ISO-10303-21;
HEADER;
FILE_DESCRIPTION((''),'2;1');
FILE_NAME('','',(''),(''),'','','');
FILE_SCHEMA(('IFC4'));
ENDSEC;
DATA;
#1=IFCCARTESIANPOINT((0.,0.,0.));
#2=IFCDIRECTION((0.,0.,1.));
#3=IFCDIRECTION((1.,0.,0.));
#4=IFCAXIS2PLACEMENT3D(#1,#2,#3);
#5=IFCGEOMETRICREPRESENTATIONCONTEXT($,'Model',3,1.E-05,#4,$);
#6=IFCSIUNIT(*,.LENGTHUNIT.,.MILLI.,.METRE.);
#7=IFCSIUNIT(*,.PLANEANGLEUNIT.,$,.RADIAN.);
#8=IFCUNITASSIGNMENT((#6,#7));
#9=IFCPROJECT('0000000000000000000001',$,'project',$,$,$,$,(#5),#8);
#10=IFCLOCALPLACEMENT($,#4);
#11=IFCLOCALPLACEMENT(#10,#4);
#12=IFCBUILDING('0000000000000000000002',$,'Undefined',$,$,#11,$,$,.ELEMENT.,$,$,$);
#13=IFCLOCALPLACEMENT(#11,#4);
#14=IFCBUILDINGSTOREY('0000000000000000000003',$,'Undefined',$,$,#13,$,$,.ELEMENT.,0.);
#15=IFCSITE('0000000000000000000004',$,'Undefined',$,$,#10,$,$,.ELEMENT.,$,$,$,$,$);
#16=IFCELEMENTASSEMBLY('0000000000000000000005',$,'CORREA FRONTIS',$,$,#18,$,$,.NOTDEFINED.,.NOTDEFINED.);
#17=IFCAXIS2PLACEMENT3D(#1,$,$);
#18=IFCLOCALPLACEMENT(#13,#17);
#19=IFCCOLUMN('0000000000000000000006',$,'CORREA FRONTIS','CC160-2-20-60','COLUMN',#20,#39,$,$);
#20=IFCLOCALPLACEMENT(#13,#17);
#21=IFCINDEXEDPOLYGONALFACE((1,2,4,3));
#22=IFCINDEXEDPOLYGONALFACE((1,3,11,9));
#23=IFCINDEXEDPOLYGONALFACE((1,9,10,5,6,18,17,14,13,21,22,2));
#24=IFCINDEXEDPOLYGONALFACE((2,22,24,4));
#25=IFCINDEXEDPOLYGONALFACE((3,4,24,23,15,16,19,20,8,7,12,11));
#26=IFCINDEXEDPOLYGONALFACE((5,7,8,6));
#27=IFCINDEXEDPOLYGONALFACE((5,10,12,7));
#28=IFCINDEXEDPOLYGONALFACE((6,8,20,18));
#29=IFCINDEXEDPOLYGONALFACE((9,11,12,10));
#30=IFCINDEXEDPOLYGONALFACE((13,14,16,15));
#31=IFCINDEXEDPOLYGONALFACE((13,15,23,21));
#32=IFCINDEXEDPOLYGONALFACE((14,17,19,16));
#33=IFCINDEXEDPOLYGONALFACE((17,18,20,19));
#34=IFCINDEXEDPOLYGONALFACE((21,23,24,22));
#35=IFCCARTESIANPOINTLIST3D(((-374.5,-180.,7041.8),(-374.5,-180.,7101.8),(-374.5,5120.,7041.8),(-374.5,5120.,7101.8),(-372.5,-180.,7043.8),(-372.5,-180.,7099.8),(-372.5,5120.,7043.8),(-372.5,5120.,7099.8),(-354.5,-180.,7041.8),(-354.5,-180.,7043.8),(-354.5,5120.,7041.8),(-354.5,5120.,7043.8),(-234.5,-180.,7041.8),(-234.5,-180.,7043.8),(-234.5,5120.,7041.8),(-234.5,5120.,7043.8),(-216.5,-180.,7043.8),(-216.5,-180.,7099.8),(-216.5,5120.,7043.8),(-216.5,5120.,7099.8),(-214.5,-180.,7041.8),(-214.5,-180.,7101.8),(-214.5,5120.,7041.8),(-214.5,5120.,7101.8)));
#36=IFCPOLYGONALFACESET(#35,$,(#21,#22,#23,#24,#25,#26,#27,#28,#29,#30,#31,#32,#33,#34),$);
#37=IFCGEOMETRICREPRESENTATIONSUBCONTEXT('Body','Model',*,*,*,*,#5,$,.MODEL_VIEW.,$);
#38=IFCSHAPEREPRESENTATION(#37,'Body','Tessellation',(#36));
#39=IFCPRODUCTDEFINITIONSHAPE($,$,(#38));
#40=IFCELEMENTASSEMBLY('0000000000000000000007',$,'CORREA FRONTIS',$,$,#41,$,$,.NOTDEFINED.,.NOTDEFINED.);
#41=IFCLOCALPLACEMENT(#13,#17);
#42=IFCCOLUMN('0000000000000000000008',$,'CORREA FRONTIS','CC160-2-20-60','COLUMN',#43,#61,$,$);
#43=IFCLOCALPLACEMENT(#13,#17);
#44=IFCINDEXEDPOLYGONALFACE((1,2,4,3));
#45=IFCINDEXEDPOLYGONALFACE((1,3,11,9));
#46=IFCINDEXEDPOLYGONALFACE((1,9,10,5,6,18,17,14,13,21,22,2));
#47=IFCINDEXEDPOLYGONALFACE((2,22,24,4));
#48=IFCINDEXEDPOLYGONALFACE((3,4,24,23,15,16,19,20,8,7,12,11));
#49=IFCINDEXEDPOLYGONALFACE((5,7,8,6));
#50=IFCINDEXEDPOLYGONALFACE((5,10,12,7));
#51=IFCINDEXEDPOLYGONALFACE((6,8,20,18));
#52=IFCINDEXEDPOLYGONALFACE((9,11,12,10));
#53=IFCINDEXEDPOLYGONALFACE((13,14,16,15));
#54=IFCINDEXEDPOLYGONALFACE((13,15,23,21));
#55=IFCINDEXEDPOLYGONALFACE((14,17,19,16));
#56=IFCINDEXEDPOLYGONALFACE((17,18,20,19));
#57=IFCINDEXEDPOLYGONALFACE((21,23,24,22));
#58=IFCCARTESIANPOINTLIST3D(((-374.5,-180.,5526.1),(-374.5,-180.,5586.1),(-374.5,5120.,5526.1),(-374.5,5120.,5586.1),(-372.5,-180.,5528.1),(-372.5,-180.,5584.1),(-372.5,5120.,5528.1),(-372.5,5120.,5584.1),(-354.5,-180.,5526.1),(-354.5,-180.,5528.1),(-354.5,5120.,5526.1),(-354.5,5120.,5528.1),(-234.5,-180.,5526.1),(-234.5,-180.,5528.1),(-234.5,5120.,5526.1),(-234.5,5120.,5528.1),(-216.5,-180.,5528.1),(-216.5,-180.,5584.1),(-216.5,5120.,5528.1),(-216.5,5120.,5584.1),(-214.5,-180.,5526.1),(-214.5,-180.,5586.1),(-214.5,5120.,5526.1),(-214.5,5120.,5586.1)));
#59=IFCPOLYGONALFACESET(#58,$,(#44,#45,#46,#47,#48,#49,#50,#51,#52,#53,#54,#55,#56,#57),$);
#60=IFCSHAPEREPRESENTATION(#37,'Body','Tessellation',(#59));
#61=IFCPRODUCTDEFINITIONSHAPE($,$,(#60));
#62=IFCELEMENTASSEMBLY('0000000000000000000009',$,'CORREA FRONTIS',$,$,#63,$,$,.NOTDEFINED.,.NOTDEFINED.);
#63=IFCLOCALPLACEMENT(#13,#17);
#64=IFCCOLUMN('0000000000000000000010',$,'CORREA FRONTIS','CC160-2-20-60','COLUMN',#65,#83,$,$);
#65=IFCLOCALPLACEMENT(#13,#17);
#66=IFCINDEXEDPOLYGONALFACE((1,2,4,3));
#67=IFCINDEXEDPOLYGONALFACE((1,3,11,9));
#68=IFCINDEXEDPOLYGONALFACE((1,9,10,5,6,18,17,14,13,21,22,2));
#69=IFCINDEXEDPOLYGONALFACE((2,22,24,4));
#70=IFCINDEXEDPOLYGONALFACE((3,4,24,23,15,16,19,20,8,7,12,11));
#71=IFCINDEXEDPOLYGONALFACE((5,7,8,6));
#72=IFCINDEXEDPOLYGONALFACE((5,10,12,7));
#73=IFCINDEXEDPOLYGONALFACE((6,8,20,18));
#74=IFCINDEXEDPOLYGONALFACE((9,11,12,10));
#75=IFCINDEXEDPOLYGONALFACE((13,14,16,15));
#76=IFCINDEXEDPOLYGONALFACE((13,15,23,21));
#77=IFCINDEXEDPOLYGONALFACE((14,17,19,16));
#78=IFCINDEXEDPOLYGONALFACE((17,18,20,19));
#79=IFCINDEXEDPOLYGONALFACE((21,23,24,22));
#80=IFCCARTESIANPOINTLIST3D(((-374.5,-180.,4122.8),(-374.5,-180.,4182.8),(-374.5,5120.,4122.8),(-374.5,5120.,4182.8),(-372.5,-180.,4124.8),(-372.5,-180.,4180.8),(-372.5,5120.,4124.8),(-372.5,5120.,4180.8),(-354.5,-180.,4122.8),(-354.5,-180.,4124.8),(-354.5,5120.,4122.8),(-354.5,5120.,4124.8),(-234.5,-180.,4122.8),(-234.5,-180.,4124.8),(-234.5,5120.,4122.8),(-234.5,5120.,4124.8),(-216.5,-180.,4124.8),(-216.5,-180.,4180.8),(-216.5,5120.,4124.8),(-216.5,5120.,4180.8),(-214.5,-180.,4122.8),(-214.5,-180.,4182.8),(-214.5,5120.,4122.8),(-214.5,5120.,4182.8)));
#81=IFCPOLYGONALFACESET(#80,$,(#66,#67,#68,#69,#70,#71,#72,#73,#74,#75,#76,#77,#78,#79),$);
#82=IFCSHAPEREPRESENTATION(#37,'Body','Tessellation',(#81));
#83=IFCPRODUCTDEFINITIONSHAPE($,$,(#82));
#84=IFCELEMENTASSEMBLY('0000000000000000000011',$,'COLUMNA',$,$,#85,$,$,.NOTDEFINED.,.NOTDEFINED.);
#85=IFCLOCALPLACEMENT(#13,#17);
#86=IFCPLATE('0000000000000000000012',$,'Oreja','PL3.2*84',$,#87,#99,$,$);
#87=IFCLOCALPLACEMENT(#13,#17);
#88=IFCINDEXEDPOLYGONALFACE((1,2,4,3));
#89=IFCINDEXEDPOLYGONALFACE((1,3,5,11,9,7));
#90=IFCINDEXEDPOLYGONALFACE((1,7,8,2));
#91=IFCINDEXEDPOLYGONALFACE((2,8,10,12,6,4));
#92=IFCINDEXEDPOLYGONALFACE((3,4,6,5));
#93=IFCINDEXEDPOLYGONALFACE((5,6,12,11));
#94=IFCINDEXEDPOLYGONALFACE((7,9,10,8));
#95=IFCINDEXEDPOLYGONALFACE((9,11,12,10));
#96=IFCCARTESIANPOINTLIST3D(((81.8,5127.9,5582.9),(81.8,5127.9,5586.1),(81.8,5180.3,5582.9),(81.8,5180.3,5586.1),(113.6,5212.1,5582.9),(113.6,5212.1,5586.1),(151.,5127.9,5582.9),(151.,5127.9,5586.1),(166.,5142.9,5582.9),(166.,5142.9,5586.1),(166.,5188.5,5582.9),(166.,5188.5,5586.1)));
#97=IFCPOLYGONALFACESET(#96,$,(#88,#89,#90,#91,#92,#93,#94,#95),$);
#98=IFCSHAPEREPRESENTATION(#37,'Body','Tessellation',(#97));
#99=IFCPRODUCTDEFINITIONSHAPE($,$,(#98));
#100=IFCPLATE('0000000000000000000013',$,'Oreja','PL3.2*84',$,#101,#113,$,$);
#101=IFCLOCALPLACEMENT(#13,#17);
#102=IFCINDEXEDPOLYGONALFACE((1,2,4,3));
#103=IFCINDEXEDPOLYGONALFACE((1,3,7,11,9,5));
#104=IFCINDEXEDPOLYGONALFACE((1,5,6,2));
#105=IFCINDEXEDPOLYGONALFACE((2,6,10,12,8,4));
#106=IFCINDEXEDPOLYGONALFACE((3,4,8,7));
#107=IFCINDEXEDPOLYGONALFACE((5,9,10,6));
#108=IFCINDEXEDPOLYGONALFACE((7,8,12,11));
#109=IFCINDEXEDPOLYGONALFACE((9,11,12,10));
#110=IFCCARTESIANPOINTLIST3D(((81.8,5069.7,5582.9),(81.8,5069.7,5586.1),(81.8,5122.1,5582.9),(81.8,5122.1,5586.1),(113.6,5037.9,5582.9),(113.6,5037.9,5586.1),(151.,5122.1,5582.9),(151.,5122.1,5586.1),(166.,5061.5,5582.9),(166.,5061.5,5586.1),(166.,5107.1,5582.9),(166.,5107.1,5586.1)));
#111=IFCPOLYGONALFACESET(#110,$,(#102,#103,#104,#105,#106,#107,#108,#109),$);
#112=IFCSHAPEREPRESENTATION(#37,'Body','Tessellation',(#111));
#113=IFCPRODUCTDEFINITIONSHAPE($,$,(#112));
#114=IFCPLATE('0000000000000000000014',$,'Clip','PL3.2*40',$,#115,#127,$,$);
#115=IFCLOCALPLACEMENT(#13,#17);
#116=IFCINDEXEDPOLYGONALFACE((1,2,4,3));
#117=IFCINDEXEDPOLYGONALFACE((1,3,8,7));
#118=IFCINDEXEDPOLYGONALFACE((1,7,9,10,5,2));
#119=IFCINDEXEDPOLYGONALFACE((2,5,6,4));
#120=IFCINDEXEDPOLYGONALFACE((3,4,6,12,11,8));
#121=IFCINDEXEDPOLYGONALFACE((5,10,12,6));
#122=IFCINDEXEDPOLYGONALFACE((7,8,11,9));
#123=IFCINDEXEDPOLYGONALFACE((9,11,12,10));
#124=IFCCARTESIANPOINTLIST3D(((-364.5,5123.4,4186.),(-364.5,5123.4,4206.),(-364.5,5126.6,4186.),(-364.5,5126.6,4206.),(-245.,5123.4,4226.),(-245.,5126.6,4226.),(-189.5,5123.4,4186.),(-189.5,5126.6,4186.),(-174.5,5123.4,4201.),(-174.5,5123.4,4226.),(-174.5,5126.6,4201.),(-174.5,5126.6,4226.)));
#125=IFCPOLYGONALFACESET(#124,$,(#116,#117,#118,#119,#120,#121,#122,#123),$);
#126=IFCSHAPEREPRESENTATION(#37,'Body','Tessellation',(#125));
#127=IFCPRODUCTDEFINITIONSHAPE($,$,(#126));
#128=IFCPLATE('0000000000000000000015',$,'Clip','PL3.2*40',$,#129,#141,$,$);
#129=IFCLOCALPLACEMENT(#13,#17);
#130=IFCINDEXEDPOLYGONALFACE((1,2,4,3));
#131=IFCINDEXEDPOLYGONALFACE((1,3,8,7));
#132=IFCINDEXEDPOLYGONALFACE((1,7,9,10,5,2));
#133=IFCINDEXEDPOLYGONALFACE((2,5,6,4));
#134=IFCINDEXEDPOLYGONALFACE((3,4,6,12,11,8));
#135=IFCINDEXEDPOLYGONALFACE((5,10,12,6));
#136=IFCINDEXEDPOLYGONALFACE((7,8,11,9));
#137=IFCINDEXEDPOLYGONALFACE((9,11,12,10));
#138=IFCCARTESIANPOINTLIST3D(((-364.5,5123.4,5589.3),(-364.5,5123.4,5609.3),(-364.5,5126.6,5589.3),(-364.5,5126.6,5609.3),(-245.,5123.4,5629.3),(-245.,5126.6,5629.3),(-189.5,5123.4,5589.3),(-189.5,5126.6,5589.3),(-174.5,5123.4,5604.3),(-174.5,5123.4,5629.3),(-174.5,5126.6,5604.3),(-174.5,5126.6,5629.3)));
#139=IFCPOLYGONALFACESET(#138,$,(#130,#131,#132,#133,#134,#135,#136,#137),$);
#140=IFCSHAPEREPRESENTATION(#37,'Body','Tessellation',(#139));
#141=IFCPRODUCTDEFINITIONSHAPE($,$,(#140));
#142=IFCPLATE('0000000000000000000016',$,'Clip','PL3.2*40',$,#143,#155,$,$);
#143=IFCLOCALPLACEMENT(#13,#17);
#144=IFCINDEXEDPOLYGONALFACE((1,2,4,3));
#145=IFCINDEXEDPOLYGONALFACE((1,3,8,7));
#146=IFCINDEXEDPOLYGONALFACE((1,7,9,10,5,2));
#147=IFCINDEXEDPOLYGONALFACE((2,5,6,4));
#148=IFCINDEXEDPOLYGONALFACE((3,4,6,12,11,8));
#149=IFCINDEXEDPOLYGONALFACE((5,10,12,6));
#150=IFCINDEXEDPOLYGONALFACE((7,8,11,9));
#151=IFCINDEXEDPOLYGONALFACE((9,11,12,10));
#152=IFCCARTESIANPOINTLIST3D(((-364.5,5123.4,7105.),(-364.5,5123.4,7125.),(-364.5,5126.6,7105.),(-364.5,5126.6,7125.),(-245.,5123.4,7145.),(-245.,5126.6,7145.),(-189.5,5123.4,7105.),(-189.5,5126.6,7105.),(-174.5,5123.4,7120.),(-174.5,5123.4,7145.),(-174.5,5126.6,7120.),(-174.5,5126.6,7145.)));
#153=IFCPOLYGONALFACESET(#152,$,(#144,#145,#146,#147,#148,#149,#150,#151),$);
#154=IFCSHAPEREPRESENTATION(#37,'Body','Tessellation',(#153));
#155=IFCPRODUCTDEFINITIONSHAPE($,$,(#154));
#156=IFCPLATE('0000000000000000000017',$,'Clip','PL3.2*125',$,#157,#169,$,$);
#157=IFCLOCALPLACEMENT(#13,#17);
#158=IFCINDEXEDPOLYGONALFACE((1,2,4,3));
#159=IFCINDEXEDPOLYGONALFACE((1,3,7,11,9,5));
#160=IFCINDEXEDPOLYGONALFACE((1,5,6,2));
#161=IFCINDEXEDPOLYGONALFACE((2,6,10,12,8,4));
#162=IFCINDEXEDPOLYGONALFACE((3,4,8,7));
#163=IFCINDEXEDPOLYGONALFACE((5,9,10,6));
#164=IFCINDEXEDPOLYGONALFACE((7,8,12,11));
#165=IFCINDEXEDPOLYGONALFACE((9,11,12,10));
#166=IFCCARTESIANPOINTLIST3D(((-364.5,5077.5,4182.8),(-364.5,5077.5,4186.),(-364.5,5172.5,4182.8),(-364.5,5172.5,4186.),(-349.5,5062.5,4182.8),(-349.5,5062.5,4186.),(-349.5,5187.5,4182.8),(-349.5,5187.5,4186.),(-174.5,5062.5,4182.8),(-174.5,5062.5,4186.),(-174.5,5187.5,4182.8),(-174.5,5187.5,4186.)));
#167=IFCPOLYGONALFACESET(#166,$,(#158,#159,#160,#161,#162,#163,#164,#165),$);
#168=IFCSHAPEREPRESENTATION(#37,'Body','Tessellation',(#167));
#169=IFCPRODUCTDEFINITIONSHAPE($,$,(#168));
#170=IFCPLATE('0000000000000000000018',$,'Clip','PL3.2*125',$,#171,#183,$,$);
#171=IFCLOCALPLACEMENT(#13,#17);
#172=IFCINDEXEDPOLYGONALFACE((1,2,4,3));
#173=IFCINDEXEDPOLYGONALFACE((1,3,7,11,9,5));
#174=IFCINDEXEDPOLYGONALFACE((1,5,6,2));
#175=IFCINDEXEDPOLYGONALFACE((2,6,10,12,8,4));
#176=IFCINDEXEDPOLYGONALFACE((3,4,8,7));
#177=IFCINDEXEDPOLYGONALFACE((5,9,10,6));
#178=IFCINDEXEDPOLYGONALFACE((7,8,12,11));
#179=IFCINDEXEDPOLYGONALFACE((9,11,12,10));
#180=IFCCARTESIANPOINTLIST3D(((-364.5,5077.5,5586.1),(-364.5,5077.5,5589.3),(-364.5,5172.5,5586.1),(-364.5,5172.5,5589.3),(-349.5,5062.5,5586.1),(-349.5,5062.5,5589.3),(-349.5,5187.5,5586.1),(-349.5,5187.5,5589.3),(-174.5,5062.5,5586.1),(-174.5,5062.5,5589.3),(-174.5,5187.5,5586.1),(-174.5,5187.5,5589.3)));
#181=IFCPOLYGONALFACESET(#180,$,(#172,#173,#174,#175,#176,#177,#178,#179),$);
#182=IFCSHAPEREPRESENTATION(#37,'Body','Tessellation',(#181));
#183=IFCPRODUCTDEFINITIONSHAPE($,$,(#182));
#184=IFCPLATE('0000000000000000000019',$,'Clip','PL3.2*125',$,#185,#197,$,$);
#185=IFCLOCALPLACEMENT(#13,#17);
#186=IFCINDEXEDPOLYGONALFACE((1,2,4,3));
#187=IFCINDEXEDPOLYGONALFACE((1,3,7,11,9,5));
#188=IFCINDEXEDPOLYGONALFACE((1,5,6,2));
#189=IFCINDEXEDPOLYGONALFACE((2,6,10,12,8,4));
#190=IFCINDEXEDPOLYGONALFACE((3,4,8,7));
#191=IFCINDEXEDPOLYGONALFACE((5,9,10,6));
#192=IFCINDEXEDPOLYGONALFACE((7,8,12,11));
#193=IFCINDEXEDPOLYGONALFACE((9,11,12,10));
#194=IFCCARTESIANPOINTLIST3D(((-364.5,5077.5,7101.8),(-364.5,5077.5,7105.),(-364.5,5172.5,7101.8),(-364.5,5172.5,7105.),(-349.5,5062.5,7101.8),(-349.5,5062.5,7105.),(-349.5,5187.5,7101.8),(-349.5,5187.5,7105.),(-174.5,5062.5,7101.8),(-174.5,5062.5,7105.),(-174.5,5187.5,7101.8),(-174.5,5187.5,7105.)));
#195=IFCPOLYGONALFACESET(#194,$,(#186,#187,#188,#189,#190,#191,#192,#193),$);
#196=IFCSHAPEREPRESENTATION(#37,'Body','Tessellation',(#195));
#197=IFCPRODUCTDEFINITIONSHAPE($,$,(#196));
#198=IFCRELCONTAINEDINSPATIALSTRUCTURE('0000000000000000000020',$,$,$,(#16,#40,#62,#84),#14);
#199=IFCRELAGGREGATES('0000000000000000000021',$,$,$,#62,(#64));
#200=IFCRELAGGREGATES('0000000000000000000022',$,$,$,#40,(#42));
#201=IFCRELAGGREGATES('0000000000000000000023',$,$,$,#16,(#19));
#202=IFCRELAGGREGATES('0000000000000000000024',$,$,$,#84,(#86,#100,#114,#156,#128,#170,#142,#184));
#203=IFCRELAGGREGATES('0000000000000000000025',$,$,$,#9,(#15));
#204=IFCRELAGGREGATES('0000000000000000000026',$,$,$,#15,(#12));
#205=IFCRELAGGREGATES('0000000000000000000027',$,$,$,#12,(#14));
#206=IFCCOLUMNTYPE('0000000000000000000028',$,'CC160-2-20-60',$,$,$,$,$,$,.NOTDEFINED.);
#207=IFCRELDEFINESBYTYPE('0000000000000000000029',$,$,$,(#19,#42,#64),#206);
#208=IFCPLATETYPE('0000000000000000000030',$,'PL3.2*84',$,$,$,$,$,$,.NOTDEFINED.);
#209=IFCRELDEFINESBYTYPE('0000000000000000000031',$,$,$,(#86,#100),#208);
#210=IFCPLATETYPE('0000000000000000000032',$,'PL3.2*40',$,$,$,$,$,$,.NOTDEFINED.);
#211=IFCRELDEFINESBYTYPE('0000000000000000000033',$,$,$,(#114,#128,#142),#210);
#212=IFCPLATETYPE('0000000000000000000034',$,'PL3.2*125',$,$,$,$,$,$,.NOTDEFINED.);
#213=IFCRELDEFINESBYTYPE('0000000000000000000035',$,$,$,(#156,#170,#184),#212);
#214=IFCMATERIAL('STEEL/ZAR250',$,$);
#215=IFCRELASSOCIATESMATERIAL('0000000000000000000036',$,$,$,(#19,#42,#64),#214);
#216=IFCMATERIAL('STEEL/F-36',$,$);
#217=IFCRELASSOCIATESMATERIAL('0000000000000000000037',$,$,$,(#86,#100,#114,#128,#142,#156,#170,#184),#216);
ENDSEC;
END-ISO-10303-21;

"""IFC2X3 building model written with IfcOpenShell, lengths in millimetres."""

from ifc_helpers import new_model, si_unit, frame, origin_with_axes, origin_2d_with_axis, place, context, subcontext, project, spatial, polyline, c_section, outline, extrude, material, type_object, element, aggregate, save


model = new_model("IFC2X3")

# Units and contexts
model_context = context("Model", 3, precision=1e-05, world=origin_with_axes())
body_context = subcontext(model_context, "Body", "Model", "MODEL_VIEW")
ifc_project = project(units=[si_unit("LENGTHUNIT", "METRE", prefix="MILLI"), si_unit("PLANEANGLEUNIT", "RADIAN")], contexts=[model_context])

# Site, building, storey
site_placement = place(None, origin_with_axes())
site = spatial("IfcSite", under=ifc_project, at=site_placement, Name="Undefined", CompositionType="ELEMENT")
building_placement = place(site_placement, origin_with_axes())
building = spatial("IfcBuilding", under=site, at=building_placement, Name="Undefined", CompositionType="ELEMENT")
storey_placement = place(building_placement, origin_with_axes())
storey = spatial("IfcBuildingStorey", under=building, at=storey_placement, Name="Undefined", CompositionType="ELEMENT", Elevation=0.0)

# Element assemblies, columns
assembly_1_placement = place(storey_placement, origin_with_axes())
assembly_1 = element("IfcElementAssembly", 1, at=assembly_1_placement, inside=storey, Name="CORREA FRONTIS", AssemblyPlace="NOTDEFINED", PredefinedType="NOTDEFINED")
ifc_material_1 = material(Name="STEEL/ZAR250")
column_type = type_object("IfcColumnType", Name="CC160-2-20-60", PredefinedType="NOTDEFINED")
column_1_placement = place(assembly_1_placement, frame((-294.5, 5120.0, 7071.8), z_axis=(0.0, -1.0, 0.0), x_axis=(-1.0, 0.0, 0.0)))
column_1 = element("IfcColumn", 2, at=column_1_placement, type_object=column_type, material=ifc_material_1, Name="CORREA FRONTIS", Description="CC160-2-20-60", ObjectType="COLUMN", context=body_context, shape_type="SweptSolid", body=[
    extrude(c_section(Depth=160.0, Width=60.0, WallThickness=2.0, Girth=20.0, at=origin_2d_with_axis()), frame((0.0, 0.0, 5300.0), z_axis=(0.0, 0.0, -1.0), x_axis=(0.0, 1.0, 0.0)), (0.0, 0.0, 1.0), 5300.0),
])
assembly_2_placement = place(storey_placement, origin_with_axes())
assembly_2 = element("IfcElementAssembly", 3, at=assembly_2_placement, inside=storey, Name="CORREA FRONTIS", AssemblyPlace="NOTDEFINED", PredefinedType="NOTDEFINED")
column_2_placement = place(assembly_2_placement, frame((-294.5, 5120.0, 5556.1), z_axis=(0.0, -1.0, 0.0), x_axis=(-1.0, 0.0, 0.0)))
column_2 = element("IfcColumn", 4, at=column_2_placement, type_object=column_type, material=ifc_material_1, Name="CORREA FRONTIS", Description="CC160-2-20-60", ObjectType="COLUMN", context=body_context, shape_type="SweptSolid", body=[
    extrude(c_section(Depth=160.0, Width=60.0, WallThickness=2.0, Girth=20.0, at=origin_2d_with_axis()), frame((0.0, 0.0, 5300.0), z_axis=(0.0, 0.0, -1.0), x_axis=(0.0, 1.0, 0.0)), (0.0, 0.0, 1.0), 5300.0),
])
assembly_3_placement = place(storey_placement, origin_with_axes())
assembly_3 = element("IfcElementAssembly", 5, at=assembly_3_placement, inside=storey, Name="CORREA FRONTIS", AssemblyPlace="NOTDEFINED", PredefinedType="NOTDEFINED")
column_3_placement = place(assembly_3_placement, frame((-294.5, 5120.0, 4152.8), z_axis=(0.0, -1.0, 0.0), x_axis=(-1.0, 0.0, 0.0)))
column_3 = element("IfcColumn", 6, at=column_3_placement, type_object=column_type, material=ifc_material_1, Name="CORREA FRONTIS", Description="CC160-2-20-60", ObjectType="COLUMN", context=body_context, shape_type="SweptSolid", body=[
    extrude(c_section(Depth=160.0, Width=60.0, WallThickness=2.0, Girth=20.0, at=origin_2d_with_axis()), frame((0.0, 0.0, 5300.0), z_axis=(0.0, 0.0, -1.0), x_axis=(0.0, 1.0, 0.0)), (0.0, 0.0, 1.0), 5300.0),
])

# Element assembly, plates
assembly_4_placement = place(storey_placement, origin_with_axes())
assembly_4 = element("IfcElementAssembly", 7, at=assembly_4_placement, inside=storey, Name="COLUMNA", AssemblyPlace="NOTDEFINED", PredefinedType="NOTDEFINED")
ifc_material_2 = material(Name="STEEL/F-36")
plate_type_1 = type_object("IfcPlateType", Name="PL3.2*84", PredefinedType="NOTDEFINED")
plate_1_placement = place(assembly_4_placement, frame((166.0, 5127.9, 5584.5), z_axis=(-0.000007, 0.0, 1.0), x_axis=(0.000008, 1.0, 0.0)))
plate_1 = element("IfcPlate", 8, at=plate_1_placement, type_object=plate_type_1, material=ifc_material_2, Name="Oreja", Description="PL3.2*84", context=body_context, shape_type="SweptSolid", body=[
    extrude(outline(polyline([(0.0, 15.0), (15.0, 0.0), (60.6, 0.0), (84.2, 52.4), (52.4, 84.2), (0.0, 84.2), (0.0, 15.0)])), frame((0.0, 0.0, -1.6), z_axis=(0.0, 0.0, 1.0), x_axis=(1.0, 0.0, 0.0)), (0.0, 0.0, 1.0), 3.2),
])
plate_2_placement = place(assembly_4_placement, frame((166.0, 5122.1, 5584.5), z_axis=(0.000007, 0.0, -1.0), x_axis=(0.000008, -1.0, 0.0)))
plate_2 = element("IfcPlate", 9, at=plate_2_placement, type_object=plate_type_1, material=ifc_material_2, Name="Oreja", Description="PL3.2*84", context=body_context, shape_type="SweptSolid", body=[
    extrude(outline(polyline([(0.0, 15.0), (15.0, 0.0), (60.6, 0.0), (84.2, 52.4), (52.4, 84.2), (0.0, 84.2), (0.0, 15.0)])), frame((0.0, 0.0, -1.6), z_axis=(0.0, 0.0, 1.0), x_axis=(1.0, 0.0, 0.0)), (0.0, 0.0, 1.0), 3.2),
])
plate_type_2 = type_object("IfcPlateType", Name="PL3.2*40", PredefinedType="NOTDEFINED")
plate_3_placement = place(assembly_4_placement, frame((-174.5, 5125.0, 4226.0), z_axis=(0.0, 1.0, 0.0), x_axis=(-0.000007, 0.0, -1.0)))
plate_3 = element("IfcPlate", 10, at=plate_3_placement, type_object=plate_type_2, material=ifc_material_2, Name="Clip", Description="PL3.2*40", context=body_context, shape_type="SweptSolid", body=[
    extrude(outline(polyline([(0.0, 0.0), (25.0, 0.0), (40.0, 15.0), (40.0, 190.0), (20.0, 190.0), (0.0, 70.5), (0.0, 0.0)])), frame((0.0, 0.0, -1.6), z_axis=(0.0, 0.0, 1.0), x_axis=(1.0, 0.0, 0.0)), (0.0, 0.0, 1.0), 3.2),
])
plate_4_placement = place(assembly_4_placement, frame((-174.5, 5125.0, 5629.3), z_axis=(0.0, 1.0, 0.0), x_axis=(-0.000007, 0.0, -1.0)))
plate_4 = element("IfcPlate", 11, at=plate_4_placement, type_object=plate_type_2, material=ifc_material_2, Name="Clip", Description="PL3.2*40", context=body_context, shape_type="SweptSolid", body=[
    extrude(outline(polyline([(0.0, 0.0), (25.0, 0.0), (40.0, 15.0), (40.0, 190.0), (20.0, 190.0), (0.0, 70.5), (0.0, 0.0)])), frame((0.0, 0.0, -1.6), z_axis=(0.0, 0.0, 1.0), x_axis=(1.0, 0.0, 0.0)), (0.0, 0.0, 1.0), 3.2),
])
plate_5_placement = place(assembly_4_placement, frame((-174.5, 5125.0, 7145.0), z_axis=(0.0, 1.0, 0.0), x_axis=(-0.000007, 0.0, -1.0)))
plate_5 = element("IfcPlate", 12, at=plate_5_placement, type_object=plate_type_2, material=ifc_material_2, Name="Clip", Description="PL3.2*40", context=body_context, shape_type="SweptSolid", body=[
    extrude(outline(polyline([(0.0, 0.0), (25.0, 0.0), (40.0, 15.0), (40.0, 190.0), (20.0, 190.0), (0.0, 70.5), (0.0, 0.0)])), frame((0.0, 0.0, -1.6), z_axis=(0.0, 0.0, 1.0), x_axis=(1.0, 0.0, 0.0)), (0.0, 0.0, 1.0), 3.2),
])
plate_type_3 = type_object("IfcPlateType", Name="PL3.2*125", PredefinedType="NOTDEFINED")
plate_6_placement = place(assembly_4_placement, frame((-174.5, 5187.5, 4184.4), z_axis=(0.000007, 0.0, -1.0), x_axis=(0.0, -1.0, 0.0)))
plate_6 = element("IfcPlate", 13, at=plate_6_placement, type_object=plate_type_3, material=ifc_material_2, Name="Clip", Description="PL3.2*125", context=body_context, shape_type="SweptSolid", body=[
    extrude(outline(polyline([(0.0, 0.0), (125.0, 0.0), (125.0, 175.0), (110.0, 190.0), (15.0, 190.0), (0.0, 175.0), (0.0, 0.0)])), frame((0.0, 0.0, -1.6), z_axis=(0.0, 0.0, 1.0), x_axis=(1.0, 0.0, 0.0)), (0.0, 0.0, 1.0), 3.2),
])
plate_7_placement = place(assembly_4_placement, frame((-174.5, 5187.5, 5587.7), z_axis=(0.000007, 0.0, -1.0), x_axis=(0.0, -1.0, 0.0)))
plate_7 = element("IfcPlate", 14, at=plate_7_placement, type_object=plate_type_3, material=ifc_material_2, Name="Clip", Description="PL3.2*125", context=body_context, shape_type="SweptSolid", body=[
    extrude(outline(polyline([(0.0, 0.0), (125.0, 0.0), (125.0, 175.0), (110.0, 190.0), (15.0, 190.0), (0.0, 175.0), (0.0, 0.0)])), frame((0.0, 0.0, -1.6), z_axis=(0.0, 0.0, 1.0), x_axis=(1.0, 0.0, 0.0)), (0.0, 0.0, 1.0), 3.2),
])
plate_8_placement = place(assembly_4_placement, frame((-174.5, 5187.5, 7103.4), z_axis=(0.000007, 0.0, -1.0), x_axis=(0.0, -1.0, 0.0)))
plate_8 = element("IfcPlate", 15, at=plate_8_placement, type_object=plate_type_3, material=ifc_material_2, Name="Clip", Description="PL3.2*125", context=body_context, shape_type="SweptSolid", body=[
    extrude(outline(polyline([(0.0, 0.0), (125.0, 0.0), (125.0, 175.0), (110.0, 190.0), (15.0, 190.0), (0.0, 175.0), (0.0, 0.0)])), frame((0.0, 0.0, -1.6), z_axis=(0.0, 0.0, 1.0), x_axis=(1.0, 0.0, 0.0)), (0.0, 0.0, 1.0), 3.2),
])

aggregate(assembly_3, [column_3])
aggregate(assembly_2, [column_2])

aggregate(assembly_1, [column_1])

aggregate(assembly_4, [plate_1, plate_2, plate_3, plate_6, plate_4, plate_7, plate_5, plate_8])

save(model, "model.ifc")
